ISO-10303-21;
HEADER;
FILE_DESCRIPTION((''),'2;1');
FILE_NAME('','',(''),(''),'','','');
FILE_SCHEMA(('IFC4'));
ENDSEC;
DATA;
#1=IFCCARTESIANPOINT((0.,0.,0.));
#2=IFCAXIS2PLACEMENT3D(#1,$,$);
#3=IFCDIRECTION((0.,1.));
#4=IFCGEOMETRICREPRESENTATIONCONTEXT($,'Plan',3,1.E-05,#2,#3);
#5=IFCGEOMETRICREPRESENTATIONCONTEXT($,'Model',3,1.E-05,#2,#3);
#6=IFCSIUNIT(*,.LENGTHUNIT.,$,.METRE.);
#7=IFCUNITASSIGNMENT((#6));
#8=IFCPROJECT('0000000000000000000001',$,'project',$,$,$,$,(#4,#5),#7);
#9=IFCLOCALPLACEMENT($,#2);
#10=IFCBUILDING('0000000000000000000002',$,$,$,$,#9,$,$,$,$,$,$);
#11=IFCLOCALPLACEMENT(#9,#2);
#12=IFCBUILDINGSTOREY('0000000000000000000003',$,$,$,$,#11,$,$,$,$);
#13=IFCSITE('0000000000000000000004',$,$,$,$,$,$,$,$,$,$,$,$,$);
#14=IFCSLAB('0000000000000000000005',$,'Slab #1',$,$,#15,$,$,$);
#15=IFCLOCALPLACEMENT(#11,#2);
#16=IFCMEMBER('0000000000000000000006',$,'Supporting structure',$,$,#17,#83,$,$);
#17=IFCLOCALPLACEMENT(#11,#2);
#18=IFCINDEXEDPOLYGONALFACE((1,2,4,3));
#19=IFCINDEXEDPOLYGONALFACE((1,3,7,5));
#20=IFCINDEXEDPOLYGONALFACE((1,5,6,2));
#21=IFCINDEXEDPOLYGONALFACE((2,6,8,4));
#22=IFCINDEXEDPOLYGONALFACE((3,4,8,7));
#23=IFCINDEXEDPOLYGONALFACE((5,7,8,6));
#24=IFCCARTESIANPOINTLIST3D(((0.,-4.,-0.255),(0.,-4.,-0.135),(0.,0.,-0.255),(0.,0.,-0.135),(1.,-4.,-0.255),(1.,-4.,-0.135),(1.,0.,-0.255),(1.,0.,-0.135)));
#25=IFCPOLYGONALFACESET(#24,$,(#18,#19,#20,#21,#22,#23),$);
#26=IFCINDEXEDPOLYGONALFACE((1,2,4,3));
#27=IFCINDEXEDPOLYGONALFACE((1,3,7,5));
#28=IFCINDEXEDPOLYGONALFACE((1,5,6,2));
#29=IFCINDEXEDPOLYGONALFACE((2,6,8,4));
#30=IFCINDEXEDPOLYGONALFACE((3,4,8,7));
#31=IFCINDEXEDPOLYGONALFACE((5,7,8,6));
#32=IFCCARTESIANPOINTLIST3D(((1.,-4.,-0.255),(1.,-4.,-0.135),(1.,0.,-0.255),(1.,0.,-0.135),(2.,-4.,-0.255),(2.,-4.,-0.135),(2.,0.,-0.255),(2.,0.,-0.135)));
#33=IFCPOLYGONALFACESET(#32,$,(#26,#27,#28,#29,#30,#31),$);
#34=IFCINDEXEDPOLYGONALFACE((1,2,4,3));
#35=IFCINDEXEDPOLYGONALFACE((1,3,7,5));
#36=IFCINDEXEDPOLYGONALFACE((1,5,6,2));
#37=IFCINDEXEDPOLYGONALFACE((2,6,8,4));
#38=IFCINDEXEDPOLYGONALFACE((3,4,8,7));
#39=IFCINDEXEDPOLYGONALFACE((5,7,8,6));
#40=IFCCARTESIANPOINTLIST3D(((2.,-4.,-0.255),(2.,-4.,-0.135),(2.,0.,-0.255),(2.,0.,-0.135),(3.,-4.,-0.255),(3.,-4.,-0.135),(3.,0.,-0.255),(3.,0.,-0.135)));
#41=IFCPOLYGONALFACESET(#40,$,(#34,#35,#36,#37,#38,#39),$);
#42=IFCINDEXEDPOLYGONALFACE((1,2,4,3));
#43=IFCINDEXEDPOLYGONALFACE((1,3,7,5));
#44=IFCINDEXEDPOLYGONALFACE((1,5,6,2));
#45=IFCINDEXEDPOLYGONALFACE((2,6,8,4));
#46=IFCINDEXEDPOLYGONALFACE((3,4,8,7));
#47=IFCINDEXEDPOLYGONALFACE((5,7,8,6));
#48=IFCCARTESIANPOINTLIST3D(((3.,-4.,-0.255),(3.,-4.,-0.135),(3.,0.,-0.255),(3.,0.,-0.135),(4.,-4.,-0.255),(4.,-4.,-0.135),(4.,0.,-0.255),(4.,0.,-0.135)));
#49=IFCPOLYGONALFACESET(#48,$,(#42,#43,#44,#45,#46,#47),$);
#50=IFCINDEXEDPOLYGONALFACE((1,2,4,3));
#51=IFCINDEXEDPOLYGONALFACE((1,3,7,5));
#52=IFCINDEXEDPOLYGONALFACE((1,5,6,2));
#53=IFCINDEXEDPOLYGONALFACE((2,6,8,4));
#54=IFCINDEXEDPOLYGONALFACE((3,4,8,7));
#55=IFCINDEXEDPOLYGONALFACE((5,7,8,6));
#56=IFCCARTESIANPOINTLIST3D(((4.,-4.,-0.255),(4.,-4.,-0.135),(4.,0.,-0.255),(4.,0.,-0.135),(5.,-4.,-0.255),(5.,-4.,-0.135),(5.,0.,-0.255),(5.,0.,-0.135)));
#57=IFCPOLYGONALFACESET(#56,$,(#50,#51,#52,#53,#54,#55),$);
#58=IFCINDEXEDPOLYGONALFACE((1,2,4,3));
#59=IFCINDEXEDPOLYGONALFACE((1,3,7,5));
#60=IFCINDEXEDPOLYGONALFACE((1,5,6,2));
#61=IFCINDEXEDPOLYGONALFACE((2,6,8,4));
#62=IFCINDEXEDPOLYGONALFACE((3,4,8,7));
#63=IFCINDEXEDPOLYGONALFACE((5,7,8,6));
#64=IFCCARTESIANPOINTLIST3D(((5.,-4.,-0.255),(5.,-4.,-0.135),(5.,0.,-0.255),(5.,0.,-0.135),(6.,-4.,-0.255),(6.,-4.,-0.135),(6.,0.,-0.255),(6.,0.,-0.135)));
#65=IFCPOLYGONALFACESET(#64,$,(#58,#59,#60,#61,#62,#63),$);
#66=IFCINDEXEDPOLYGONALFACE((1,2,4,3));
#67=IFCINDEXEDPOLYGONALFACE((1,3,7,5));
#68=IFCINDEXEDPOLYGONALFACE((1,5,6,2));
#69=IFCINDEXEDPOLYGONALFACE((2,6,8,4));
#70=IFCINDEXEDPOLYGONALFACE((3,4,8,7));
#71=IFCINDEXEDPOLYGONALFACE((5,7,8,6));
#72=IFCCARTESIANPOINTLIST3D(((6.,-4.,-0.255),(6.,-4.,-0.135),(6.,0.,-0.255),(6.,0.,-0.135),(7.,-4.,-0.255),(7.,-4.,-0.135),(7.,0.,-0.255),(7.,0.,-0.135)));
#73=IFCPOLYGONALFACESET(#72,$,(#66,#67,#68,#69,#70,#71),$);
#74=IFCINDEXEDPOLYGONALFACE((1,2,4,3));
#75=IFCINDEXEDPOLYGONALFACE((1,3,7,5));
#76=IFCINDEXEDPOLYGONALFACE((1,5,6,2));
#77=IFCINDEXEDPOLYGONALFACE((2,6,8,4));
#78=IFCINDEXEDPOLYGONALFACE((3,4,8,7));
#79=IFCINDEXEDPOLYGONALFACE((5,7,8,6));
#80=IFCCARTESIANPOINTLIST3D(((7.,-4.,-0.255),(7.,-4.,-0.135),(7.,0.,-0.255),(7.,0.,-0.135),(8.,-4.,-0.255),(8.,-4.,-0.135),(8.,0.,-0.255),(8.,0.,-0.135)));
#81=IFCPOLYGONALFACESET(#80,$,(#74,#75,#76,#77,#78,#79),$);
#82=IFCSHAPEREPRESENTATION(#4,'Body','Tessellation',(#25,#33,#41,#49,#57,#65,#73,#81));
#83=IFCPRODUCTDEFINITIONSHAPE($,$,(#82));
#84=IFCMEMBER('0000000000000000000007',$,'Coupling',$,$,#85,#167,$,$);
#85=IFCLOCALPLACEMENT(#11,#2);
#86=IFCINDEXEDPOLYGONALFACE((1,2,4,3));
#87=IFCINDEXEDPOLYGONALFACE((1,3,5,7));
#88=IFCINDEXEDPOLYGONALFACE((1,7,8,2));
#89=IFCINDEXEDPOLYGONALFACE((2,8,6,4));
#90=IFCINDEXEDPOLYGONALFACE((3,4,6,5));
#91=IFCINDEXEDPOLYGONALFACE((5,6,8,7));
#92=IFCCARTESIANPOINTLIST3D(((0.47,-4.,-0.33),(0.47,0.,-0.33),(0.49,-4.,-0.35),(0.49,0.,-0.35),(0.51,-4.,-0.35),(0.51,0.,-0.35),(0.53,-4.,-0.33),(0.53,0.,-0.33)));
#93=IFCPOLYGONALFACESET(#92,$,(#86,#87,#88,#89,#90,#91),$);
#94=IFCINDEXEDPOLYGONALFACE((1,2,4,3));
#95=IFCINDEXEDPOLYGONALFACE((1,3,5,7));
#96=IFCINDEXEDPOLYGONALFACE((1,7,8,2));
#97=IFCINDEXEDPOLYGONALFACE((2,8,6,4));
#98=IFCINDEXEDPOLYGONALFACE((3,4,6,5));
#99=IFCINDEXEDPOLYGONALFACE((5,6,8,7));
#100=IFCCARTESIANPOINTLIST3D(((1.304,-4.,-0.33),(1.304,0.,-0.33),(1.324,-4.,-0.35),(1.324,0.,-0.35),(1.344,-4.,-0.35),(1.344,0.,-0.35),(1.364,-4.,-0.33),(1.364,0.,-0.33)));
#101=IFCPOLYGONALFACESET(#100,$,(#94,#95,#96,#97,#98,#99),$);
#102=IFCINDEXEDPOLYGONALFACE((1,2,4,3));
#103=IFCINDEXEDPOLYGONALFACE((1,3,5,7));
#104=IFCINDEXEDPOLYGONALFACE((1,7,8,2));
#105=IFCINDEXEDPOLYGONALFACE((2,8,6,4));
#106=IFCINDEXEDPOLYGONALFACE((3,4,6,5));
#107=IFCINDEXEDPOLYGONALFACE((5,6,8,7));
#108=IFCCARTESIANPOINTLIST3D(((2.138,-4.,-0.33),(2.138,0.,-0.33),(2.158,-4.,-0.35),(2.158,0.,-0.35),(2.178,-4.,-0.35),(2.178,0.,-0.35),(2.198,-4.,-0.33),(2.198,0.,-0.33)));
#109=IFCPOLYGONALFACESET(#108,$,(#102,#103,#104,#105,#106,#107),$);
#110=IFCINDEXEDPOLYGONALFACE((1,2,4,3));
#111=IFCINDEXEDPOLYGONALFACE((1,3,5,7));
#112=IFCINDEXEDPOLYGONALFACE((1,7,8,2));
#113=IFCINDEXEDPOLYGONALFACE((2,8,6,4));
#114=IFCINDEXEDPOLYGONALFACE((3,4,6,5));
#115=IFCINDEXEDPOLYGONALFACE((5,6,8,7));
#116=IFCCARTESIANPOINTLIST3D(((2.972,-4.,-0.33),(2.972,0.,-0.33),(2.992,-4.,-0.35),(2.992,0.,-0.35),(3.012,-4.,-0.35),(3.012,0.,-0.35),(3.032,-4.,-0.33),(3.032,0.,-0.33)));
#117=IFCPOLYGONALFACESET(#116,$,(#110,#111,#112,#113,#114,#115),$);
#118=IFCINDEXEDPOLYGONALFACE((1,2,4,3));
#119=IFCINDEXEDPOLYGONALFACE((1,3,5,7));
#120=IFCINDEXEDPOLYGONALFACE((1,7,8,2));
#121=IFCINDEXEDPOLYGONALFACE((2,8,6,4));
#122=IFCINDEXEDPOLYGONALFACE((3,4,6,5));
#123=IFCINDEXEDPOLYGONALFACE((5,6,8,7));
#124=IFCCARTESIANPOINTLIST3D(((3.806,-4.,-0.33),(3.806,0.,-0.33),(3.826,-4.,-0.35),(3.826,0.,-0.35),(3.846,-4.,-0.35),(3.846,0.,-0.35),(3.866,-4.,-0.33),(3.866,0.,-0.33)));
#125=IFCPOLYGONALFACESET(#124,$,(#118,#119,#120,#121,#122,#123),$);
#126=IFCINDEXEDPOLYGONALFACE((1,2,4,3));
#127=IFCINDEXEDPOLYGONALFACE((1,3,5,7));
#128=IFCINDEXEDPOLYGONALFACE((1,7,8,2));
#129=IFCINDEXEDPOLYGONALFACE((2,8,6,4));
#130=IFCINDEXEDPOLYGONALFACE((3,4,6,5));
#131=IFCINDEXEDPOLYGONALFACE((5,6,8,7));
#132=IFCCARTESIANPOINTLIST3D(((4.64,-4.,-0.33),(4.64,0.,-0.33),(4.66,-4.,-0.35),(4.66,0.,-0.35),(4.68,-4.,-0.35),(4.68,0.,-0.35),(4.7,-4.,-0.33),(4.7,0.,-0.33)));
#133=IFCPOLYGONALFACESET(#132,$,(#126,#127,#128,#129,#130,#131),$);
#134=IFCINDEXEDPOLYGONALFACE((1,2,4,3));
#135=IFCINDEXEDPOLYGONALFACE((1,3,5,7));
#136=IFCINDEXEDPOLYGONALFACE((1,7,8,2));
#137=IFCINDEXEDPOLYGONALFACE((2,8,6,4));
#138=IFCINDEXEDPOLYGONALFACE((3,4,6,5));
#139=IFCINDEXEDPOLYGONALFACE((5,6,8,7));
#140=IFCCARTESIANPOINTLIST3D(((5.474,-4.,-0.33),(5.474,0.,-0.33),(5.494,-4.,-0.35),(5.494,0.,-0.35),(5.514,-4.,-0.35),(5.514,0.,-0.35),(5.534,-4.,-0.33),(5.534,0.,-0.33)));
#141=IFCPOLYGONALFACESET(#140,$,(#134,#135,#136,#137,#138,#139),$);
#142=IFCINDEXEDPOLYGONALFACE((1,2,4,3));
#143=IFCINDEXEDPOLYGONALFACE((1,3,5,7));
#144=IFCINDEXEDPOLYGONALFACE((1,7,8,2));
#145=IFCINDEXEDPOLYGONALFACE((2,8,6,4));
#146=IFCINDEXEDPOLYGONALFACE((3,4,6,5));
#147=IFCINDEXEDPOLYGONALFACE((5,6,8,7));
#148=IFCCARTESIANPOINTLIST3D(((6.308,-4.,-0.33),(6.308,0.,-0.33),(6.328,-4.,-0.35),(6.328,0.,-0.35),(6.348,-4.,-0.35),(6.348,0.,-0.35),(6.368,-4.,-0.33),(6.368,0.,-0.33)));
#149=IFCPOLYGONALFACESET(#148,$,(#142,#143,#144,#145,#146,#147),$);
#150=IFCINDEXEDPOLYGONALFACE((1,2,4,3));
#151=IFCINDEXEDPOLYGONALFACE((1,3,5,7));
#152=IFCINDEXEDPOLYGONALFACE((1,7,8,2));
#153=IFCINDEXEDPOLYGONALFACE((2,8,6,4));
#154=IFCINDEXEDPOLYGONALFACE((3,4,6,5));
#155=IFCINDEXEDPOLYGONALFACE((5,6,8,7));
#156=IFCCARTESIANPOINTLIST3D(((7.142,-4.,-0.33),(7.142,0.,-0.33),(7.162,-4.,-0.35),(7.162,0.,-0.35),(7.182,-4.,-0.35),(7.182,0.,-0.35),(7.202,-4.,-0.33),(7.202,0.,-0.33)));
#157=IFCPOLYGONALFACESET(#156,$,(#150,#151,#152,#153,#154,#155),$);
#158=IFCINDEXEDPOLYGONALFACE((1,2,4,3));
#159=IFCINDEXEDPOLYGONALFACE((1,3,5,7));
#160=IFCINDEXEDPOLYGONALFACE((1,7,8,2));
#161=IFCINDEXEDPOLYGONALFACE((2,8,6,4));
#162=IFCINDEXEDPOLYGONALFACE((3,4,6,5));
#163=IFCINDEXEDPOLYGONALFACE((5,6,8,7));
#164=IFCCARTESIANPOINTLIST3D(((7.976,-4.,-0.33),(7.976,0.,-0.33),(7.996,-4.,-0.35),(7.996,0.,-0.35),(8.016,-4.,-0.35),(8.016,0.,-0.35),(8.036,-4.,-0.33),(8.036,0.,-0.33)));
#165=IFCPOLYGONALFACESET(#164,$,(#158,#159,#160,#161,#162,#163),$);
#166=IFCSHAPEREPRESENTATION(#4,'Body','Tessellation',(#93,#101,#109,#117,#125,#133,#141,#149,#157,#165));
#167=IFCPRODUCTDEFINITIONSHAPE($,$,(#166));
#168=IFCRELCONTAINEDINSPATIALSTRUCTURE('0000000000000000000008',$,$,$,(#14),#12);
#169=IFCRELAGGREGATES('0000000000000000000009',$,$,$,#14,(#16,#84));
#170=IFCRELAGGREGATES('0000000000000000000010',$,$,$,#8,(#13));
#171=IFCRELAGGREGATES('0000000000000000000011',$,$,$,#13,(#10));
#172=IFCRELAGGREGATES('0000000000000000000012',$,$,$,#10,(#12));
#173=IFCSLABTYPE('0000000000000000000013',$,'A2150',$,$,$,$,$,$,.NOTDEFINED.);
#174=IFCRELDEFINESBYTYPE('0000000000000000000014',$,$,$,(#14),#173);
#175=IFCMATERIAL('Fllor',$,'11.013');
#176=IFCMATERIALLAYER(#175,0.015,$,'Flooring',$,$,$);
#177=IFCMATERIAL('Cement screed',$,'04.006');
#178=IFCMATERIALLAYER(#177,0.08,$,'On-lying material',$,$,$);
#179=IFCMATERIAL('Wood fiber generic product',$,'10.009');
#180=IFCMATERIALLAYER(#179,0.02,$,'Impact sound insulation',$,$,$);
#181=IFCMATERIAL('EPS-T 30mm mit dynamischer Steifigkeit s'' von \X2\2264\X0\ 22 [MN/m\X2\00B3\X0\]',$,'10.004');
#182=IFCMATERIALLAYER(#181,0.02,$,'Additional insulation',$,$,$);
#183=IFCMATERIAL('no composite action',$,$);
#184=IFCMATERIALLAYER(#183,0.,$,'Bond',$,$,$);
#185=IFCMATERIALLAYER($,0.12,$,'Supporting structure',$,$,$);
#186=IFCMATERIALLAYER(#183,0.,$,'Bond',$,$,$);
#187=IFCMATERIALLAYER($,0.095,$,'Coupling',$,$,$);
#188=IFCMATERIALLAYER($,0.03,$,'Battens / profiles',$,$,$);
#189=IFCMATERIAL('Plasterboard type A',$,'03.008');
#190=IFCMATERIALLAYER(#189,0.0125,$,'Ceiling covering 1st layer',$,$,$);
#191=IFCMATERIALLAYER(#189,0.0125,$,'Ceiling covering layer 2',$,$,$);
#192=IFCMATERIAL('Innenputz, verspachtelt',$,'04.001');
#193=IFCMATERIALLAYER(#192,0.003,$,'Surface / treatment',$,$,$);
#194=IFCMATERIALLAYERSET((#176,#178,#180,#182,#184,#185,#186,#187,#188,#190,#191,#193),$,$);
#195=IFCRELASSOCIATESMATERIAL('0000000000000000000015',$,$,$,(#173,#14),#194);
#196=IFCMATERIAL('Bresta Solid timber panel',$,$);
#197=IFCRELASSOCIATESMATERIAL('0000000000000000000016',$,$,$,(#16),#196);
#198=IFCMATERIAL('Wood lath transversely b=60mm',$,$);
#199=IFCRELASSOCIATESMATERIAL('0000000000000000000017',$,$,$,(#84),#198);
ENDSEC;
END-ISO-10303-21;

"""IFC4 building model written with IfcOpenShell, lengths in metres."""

from ifc_helpers import new_model, si_unit, direction, frame, frame_2d, origin, place, context, project, spatial, polyline, rectangle, outline, extrude, material, layer, layer_set, type_object, element, aggregate, save


model = new_model("IFC4")

# Units and contexts
plan_context = context("Plan", 3, precision=1e-05, world=origin(), true_north=direction((0.0, 1.0)))
model_context = context("Model", 3, precision=1e-05, world=origin(), true_north=direction((0.0, 1.0)))
ifc_project = project(units=[si_unit("LENGTHUNIT", "METRE")], contexts=[plan_context, model_context])

# Site, building, storey
site = spatial("IfcSite", under=ifc_project)
building_placement = place(None, origin())
building = spatial("IfcBuilding", under=site, at=building_placement)
storey_placement = place(building_placement, origin())
storey = spatial("IfcBuildingStorey", under=building, at=storey_placement)

# Slab, members
ifc_material_1 = material(Name="Fllor", Category="11.013")
ifc_layer_1 = layer(ifc_material_1, 0.015, Name="Flooring")
ifc_material_2 = material(Name="Cement screed", Category="04.006")
ifc_layer_2 = layer(ifc_material_2, 0.08, Name="On-lying material")
ifc_material_3 = material(Name="Wood fiber generic product", Category="10.009")
ifc_layer_3 = layer(ifc_material_3, 0.02, Name="Impact sound insulation")
ifc_material_4 = material(Name="EPS-T 30mm mit dynamischer Steifigkeit s' von ≤ 22 [MN/m³]", Category="10.004")
ifc_layer_4 = layer(ifc_material_4, 0.02, Name="Additional insulation")
ifc_material_5 = material(Name="no composite action")
ifc_layer_5 = layer(ifc_material_5, 0.0, Name="Bond")
ifc_layer_6 = layer(None, 0.12, Name="Supporting structure")
ifc_layer_7 = layer(ifc_material_5, 0.0, Name="Bond")
ifc_layer_8 = layer(None, 0.095, Name="Coupling")
ifc_layer_9 = layer(None, 0.03, Name="Battens / profiles")
ifc_material_6 = material(Name="Plasterboard type A", Category="03.008")
ifc_layer_10 = layer(ifc_material_6, 0.0125, Name="Ceiling covering 1st layer")
ifc_layer_11 = layer(ifc_material_6, 0.0125, Name="Ceiling covering layer 2")
ifc_material_7 = material(Name="Innenputz, verspachtelt", Category="04.001")
ifc_layer_12 = layer(ifc_material_7, 0.003, Name="Surface / treatment")
ifc_layer_set = layer_set([ifc_layer_1, ifc_layer_2, ifc_layer_3, ifc_layer_4, ifc_layer_5, ifc_layer_6, ifc_layer_7, ifc_layer_8, ifc_layer_9, ifc_layer_10, ifc_layer_11, ifc_layer_12])
slab_type = type_object("IfcSlabType", Name="A2150", PredefinedType="NOTDEFINED", material=ifc_layer_set)
slab_placement = place(None, frame((0.0, 0.0, 0.0), z_axis=(0.0, 0.0, -1.0), x_axis=(1.0, 0.0, 0.0)))
slab = element("IfcSlab", 1, at=slab_placement, inside=storey, type_object=slab_type, material=ifc_layer_set, Name="Slab #1")
ifc_material_8 = material(Name="Bresta Solid timber panel")
member_1_placement = place(slab_placement, origin())
member_1 = element("IfcMember", 2, at=member_1_placement, material=ifc_material_8, Name="Supporting structure", context=plan_context, shape_type="SweptSolid", body=[
    extrude(rectangle(XDim=1.0, YDim=0.12, at=frame_2d((0.5, 0.06), x_axis=(1.0, 0.0))), frame((0.0, 4.0, 0.135), z_axis=(0.0, -1.0, 0.0), x_axis=(1.0, 0.0, 0.0)), (0.0, 0.0, 1.0), 4.0),
    extrude(rectangle(XDim=1.0, YDim=0.12, at=frame_2d((0.5, 0.06), x_axis=(1.0, 0.0))), frame((1.0, 4.0, 0.135), z_axis=(0.0, -1.0, 0.0), x_axis=(1.0, 0.0, 0.0)), (0.0, 0.0, 1.0), 4.0),
    extrude(rectangle(XDim=1.0, YDim=0.12, at=frame_2d((0.5, 0.06), x_axis=(1.0, 0.0))), frame((2.0, 4.0, 0.135), z_axis=(0.0, -1.0, 0.0), x_axis=(1.0, 0.0, 0.0)), (0.0, 0.0, 1.0), 4.0),
    extrude(rectangle(XDim=1.0, YDim=0.12, at=frame_2d((0.5, 0.06), x_axis=(1.0, 0.0))), frame((3.0, 4.0, 0.135), z_axis=(0.0, -1.0, 0.0), x_axis=(1.0, 0.0, 0.0)), (0.0, 0.0, 1.0), 4.0),
    extrude(rectangle(XDim=1.0, YDim=0.12, at=frame_2d((0.5, 0.06), x_axis=(1.0, 0.0))), frame((4.0, 4.0, 0.135), z_axis=(0.0, -1.0, 0.0), x_axis=(1.0, 0.0, 0.0)), (0.0, 0.0, 1.0), 4.0),
    extrude(rectangle(XDim=1.0, YDim=0.12, at=frame_2d((0.5, 0.06), x_axis=(1.0, 0.0))), frame((5.0, 4.0, 0.135), z_axis=(0.0, -1.0, 0.0), x_axis=(1.0, 0.0, 0.0)), (0.0, 0.0, 1.0), 4.0),
    extrude(rectangle(XDim=1.0, YDim=0.12, at=frame_2d((0.5, 0.06), x_axis=(1.0, 0.0))), frame((6.0, 4.0, 0.135), z_axis=(0.0, -1.0, 0.0), x_axis=(1.0, 0.0, 0.0)), (0.0, 0.0, 1.0), 4.0),
    extrude(rectangle(XDim=1.0, YDim=0.12, at=frame_2d((0.5, 0.06), x_axis=(1.0, 0.0))), frame((7.0, 4.0, 0.135), z_axis=(0.0, -1.0, 0.0), x_axis=(1.0, 0.0, 0.0)), (0.0, 0.0, 1.0), 4.0),
])
ifc_material_9 = material(Name="Wood lath transversely b=60mm")
member_2_placement = place(slab_placement, origin())
member_2 = element("IfcMember", 3, at=member_2_placement, material=ifc_material_9, Name="Coupling", context=plan_context, shape_type="SweptSolid", body=[
    extrude(outline(polyline([(0.0, 0.0), (0.06, 0.0), (0.04, 0.02), (0.02, 0.02), (0.0, 0.0)])), frame((0.47, 4.0, 0.33), z_axis=(0.0, -1.0, 0.0), x_axis=(1.0, 0.0, 0.0)), (0.0, 0.0, 1.0), 4.0),
    extrude(outline(polyline([(0.0, 0.0), (0.06, 0.0), (0.04, 0.02), (0.02, 0.02), (0.0, 0.0)])), frame((1.304, 4.0, 0.33), z_axis=(0.0, -1.0, 0.0), x_axis=(1.0, 0.0, 0.0)), (0.0, 0.0, 1.0), 4.0),
    extrude(outline(polyline([(0.0, 0.0), (0.06, 0.0), (0.04, 0.02), (0.02, 0.02), (0.0, 0.0)])), frame((2.138, 4.0, 0.33), z_axis=(0.0, -1.0, 0.0), x_axis=(1.0, 0.0, 0.0)), (0.0, 0.0, 1.0), 4.0),
    extrude(outline(polyline([(0.0, 0.0), (0.06, 0.0), (0.04, 0.02), (0.02, 0.02), (0.0, 0.0)])), frame((2.972, 4.0, 0.33), z_axis=(0.0, -1.0, 0.0), x_axis=(1.0, 0.0, 0.0)), (0.0, 0.0, 1.0), 4.0),
    extrude(outline(polyline([(0.0, 0.0), (0.06, 0.0), (0.04, 0.02), (0.02, 0.02), (0.0, 0.0)])), frame((3.806, 4.0, 0.33), z_axis=(0.0, -1.0, 0.0), x_axis=(1.0, 0.0, 0.0)), (0.0, 0.0, 1.0), 4.0),
    extrude(outline(polyline([(0.0, 0.0), (0.06, 0.0), (0.04, 0.02), (0.02, 0.02), (0.0, 0.0)])), frame((4.64, 4.0, 0.33), z_axis=(0.0, -1.0, 0.0), x_axis=(1.0, 0.0, 0.0)), (0.0, 0.0, 1.0), 4.0),
    extrude(outline(polyline([(0.0, 0.0), (0.06, 0.0), (0.04, 0.02), (0.02, 0.02), (0.0, 0.0)])), frame((5.474, 4.0, 0.33), z_axis=(0.0, -1.0, 0.0), x_axis=(1.0, 0.0, 0.0)), (0.0, 0.0, 1.0), 4.0),
    extrude(outline(polyline([(0.0, 0.0), (0.06, 0.0), (0.04, 0.02), (0.02, 0.02), (0.0, 0.0)])), frame((6.308, 4.0, 0.33), z_axis=(0.0, -1.0, 0.0), x_axis=(1.0, 0.0, 0.0)), (0.0, 0.0, 1.0), 4.0),
    extrude(outline(polyline([(0.0, 0.0), (0.06, 0.0), (0.04, 0.02), (0.02, 0.02), (0.0, 0.0)])), frame((7.142, 4.0, 0.33), z_axis=(0.0, -1.0, 0.0), x_axis=(1.0, 0.0, 0.0)), (0.0, 0.0, 1.0), 4.0),
    extrude(outline(polyline([(0.0, 0.0), (0.06, 0.0), (0.04, 0.02), (0.02, 0.02), (0.0, 0.0)])), frame((7.976, 4.0, 0.33), z_axis=(0.0, -1.0, 0.0), x_axis=(1.0, 0.0, 0.0)), (0.0, 0.0, 1.0), 4.0),
])
aggregate(slab, [member_1, member_2])

save(model, "model.ifc")
